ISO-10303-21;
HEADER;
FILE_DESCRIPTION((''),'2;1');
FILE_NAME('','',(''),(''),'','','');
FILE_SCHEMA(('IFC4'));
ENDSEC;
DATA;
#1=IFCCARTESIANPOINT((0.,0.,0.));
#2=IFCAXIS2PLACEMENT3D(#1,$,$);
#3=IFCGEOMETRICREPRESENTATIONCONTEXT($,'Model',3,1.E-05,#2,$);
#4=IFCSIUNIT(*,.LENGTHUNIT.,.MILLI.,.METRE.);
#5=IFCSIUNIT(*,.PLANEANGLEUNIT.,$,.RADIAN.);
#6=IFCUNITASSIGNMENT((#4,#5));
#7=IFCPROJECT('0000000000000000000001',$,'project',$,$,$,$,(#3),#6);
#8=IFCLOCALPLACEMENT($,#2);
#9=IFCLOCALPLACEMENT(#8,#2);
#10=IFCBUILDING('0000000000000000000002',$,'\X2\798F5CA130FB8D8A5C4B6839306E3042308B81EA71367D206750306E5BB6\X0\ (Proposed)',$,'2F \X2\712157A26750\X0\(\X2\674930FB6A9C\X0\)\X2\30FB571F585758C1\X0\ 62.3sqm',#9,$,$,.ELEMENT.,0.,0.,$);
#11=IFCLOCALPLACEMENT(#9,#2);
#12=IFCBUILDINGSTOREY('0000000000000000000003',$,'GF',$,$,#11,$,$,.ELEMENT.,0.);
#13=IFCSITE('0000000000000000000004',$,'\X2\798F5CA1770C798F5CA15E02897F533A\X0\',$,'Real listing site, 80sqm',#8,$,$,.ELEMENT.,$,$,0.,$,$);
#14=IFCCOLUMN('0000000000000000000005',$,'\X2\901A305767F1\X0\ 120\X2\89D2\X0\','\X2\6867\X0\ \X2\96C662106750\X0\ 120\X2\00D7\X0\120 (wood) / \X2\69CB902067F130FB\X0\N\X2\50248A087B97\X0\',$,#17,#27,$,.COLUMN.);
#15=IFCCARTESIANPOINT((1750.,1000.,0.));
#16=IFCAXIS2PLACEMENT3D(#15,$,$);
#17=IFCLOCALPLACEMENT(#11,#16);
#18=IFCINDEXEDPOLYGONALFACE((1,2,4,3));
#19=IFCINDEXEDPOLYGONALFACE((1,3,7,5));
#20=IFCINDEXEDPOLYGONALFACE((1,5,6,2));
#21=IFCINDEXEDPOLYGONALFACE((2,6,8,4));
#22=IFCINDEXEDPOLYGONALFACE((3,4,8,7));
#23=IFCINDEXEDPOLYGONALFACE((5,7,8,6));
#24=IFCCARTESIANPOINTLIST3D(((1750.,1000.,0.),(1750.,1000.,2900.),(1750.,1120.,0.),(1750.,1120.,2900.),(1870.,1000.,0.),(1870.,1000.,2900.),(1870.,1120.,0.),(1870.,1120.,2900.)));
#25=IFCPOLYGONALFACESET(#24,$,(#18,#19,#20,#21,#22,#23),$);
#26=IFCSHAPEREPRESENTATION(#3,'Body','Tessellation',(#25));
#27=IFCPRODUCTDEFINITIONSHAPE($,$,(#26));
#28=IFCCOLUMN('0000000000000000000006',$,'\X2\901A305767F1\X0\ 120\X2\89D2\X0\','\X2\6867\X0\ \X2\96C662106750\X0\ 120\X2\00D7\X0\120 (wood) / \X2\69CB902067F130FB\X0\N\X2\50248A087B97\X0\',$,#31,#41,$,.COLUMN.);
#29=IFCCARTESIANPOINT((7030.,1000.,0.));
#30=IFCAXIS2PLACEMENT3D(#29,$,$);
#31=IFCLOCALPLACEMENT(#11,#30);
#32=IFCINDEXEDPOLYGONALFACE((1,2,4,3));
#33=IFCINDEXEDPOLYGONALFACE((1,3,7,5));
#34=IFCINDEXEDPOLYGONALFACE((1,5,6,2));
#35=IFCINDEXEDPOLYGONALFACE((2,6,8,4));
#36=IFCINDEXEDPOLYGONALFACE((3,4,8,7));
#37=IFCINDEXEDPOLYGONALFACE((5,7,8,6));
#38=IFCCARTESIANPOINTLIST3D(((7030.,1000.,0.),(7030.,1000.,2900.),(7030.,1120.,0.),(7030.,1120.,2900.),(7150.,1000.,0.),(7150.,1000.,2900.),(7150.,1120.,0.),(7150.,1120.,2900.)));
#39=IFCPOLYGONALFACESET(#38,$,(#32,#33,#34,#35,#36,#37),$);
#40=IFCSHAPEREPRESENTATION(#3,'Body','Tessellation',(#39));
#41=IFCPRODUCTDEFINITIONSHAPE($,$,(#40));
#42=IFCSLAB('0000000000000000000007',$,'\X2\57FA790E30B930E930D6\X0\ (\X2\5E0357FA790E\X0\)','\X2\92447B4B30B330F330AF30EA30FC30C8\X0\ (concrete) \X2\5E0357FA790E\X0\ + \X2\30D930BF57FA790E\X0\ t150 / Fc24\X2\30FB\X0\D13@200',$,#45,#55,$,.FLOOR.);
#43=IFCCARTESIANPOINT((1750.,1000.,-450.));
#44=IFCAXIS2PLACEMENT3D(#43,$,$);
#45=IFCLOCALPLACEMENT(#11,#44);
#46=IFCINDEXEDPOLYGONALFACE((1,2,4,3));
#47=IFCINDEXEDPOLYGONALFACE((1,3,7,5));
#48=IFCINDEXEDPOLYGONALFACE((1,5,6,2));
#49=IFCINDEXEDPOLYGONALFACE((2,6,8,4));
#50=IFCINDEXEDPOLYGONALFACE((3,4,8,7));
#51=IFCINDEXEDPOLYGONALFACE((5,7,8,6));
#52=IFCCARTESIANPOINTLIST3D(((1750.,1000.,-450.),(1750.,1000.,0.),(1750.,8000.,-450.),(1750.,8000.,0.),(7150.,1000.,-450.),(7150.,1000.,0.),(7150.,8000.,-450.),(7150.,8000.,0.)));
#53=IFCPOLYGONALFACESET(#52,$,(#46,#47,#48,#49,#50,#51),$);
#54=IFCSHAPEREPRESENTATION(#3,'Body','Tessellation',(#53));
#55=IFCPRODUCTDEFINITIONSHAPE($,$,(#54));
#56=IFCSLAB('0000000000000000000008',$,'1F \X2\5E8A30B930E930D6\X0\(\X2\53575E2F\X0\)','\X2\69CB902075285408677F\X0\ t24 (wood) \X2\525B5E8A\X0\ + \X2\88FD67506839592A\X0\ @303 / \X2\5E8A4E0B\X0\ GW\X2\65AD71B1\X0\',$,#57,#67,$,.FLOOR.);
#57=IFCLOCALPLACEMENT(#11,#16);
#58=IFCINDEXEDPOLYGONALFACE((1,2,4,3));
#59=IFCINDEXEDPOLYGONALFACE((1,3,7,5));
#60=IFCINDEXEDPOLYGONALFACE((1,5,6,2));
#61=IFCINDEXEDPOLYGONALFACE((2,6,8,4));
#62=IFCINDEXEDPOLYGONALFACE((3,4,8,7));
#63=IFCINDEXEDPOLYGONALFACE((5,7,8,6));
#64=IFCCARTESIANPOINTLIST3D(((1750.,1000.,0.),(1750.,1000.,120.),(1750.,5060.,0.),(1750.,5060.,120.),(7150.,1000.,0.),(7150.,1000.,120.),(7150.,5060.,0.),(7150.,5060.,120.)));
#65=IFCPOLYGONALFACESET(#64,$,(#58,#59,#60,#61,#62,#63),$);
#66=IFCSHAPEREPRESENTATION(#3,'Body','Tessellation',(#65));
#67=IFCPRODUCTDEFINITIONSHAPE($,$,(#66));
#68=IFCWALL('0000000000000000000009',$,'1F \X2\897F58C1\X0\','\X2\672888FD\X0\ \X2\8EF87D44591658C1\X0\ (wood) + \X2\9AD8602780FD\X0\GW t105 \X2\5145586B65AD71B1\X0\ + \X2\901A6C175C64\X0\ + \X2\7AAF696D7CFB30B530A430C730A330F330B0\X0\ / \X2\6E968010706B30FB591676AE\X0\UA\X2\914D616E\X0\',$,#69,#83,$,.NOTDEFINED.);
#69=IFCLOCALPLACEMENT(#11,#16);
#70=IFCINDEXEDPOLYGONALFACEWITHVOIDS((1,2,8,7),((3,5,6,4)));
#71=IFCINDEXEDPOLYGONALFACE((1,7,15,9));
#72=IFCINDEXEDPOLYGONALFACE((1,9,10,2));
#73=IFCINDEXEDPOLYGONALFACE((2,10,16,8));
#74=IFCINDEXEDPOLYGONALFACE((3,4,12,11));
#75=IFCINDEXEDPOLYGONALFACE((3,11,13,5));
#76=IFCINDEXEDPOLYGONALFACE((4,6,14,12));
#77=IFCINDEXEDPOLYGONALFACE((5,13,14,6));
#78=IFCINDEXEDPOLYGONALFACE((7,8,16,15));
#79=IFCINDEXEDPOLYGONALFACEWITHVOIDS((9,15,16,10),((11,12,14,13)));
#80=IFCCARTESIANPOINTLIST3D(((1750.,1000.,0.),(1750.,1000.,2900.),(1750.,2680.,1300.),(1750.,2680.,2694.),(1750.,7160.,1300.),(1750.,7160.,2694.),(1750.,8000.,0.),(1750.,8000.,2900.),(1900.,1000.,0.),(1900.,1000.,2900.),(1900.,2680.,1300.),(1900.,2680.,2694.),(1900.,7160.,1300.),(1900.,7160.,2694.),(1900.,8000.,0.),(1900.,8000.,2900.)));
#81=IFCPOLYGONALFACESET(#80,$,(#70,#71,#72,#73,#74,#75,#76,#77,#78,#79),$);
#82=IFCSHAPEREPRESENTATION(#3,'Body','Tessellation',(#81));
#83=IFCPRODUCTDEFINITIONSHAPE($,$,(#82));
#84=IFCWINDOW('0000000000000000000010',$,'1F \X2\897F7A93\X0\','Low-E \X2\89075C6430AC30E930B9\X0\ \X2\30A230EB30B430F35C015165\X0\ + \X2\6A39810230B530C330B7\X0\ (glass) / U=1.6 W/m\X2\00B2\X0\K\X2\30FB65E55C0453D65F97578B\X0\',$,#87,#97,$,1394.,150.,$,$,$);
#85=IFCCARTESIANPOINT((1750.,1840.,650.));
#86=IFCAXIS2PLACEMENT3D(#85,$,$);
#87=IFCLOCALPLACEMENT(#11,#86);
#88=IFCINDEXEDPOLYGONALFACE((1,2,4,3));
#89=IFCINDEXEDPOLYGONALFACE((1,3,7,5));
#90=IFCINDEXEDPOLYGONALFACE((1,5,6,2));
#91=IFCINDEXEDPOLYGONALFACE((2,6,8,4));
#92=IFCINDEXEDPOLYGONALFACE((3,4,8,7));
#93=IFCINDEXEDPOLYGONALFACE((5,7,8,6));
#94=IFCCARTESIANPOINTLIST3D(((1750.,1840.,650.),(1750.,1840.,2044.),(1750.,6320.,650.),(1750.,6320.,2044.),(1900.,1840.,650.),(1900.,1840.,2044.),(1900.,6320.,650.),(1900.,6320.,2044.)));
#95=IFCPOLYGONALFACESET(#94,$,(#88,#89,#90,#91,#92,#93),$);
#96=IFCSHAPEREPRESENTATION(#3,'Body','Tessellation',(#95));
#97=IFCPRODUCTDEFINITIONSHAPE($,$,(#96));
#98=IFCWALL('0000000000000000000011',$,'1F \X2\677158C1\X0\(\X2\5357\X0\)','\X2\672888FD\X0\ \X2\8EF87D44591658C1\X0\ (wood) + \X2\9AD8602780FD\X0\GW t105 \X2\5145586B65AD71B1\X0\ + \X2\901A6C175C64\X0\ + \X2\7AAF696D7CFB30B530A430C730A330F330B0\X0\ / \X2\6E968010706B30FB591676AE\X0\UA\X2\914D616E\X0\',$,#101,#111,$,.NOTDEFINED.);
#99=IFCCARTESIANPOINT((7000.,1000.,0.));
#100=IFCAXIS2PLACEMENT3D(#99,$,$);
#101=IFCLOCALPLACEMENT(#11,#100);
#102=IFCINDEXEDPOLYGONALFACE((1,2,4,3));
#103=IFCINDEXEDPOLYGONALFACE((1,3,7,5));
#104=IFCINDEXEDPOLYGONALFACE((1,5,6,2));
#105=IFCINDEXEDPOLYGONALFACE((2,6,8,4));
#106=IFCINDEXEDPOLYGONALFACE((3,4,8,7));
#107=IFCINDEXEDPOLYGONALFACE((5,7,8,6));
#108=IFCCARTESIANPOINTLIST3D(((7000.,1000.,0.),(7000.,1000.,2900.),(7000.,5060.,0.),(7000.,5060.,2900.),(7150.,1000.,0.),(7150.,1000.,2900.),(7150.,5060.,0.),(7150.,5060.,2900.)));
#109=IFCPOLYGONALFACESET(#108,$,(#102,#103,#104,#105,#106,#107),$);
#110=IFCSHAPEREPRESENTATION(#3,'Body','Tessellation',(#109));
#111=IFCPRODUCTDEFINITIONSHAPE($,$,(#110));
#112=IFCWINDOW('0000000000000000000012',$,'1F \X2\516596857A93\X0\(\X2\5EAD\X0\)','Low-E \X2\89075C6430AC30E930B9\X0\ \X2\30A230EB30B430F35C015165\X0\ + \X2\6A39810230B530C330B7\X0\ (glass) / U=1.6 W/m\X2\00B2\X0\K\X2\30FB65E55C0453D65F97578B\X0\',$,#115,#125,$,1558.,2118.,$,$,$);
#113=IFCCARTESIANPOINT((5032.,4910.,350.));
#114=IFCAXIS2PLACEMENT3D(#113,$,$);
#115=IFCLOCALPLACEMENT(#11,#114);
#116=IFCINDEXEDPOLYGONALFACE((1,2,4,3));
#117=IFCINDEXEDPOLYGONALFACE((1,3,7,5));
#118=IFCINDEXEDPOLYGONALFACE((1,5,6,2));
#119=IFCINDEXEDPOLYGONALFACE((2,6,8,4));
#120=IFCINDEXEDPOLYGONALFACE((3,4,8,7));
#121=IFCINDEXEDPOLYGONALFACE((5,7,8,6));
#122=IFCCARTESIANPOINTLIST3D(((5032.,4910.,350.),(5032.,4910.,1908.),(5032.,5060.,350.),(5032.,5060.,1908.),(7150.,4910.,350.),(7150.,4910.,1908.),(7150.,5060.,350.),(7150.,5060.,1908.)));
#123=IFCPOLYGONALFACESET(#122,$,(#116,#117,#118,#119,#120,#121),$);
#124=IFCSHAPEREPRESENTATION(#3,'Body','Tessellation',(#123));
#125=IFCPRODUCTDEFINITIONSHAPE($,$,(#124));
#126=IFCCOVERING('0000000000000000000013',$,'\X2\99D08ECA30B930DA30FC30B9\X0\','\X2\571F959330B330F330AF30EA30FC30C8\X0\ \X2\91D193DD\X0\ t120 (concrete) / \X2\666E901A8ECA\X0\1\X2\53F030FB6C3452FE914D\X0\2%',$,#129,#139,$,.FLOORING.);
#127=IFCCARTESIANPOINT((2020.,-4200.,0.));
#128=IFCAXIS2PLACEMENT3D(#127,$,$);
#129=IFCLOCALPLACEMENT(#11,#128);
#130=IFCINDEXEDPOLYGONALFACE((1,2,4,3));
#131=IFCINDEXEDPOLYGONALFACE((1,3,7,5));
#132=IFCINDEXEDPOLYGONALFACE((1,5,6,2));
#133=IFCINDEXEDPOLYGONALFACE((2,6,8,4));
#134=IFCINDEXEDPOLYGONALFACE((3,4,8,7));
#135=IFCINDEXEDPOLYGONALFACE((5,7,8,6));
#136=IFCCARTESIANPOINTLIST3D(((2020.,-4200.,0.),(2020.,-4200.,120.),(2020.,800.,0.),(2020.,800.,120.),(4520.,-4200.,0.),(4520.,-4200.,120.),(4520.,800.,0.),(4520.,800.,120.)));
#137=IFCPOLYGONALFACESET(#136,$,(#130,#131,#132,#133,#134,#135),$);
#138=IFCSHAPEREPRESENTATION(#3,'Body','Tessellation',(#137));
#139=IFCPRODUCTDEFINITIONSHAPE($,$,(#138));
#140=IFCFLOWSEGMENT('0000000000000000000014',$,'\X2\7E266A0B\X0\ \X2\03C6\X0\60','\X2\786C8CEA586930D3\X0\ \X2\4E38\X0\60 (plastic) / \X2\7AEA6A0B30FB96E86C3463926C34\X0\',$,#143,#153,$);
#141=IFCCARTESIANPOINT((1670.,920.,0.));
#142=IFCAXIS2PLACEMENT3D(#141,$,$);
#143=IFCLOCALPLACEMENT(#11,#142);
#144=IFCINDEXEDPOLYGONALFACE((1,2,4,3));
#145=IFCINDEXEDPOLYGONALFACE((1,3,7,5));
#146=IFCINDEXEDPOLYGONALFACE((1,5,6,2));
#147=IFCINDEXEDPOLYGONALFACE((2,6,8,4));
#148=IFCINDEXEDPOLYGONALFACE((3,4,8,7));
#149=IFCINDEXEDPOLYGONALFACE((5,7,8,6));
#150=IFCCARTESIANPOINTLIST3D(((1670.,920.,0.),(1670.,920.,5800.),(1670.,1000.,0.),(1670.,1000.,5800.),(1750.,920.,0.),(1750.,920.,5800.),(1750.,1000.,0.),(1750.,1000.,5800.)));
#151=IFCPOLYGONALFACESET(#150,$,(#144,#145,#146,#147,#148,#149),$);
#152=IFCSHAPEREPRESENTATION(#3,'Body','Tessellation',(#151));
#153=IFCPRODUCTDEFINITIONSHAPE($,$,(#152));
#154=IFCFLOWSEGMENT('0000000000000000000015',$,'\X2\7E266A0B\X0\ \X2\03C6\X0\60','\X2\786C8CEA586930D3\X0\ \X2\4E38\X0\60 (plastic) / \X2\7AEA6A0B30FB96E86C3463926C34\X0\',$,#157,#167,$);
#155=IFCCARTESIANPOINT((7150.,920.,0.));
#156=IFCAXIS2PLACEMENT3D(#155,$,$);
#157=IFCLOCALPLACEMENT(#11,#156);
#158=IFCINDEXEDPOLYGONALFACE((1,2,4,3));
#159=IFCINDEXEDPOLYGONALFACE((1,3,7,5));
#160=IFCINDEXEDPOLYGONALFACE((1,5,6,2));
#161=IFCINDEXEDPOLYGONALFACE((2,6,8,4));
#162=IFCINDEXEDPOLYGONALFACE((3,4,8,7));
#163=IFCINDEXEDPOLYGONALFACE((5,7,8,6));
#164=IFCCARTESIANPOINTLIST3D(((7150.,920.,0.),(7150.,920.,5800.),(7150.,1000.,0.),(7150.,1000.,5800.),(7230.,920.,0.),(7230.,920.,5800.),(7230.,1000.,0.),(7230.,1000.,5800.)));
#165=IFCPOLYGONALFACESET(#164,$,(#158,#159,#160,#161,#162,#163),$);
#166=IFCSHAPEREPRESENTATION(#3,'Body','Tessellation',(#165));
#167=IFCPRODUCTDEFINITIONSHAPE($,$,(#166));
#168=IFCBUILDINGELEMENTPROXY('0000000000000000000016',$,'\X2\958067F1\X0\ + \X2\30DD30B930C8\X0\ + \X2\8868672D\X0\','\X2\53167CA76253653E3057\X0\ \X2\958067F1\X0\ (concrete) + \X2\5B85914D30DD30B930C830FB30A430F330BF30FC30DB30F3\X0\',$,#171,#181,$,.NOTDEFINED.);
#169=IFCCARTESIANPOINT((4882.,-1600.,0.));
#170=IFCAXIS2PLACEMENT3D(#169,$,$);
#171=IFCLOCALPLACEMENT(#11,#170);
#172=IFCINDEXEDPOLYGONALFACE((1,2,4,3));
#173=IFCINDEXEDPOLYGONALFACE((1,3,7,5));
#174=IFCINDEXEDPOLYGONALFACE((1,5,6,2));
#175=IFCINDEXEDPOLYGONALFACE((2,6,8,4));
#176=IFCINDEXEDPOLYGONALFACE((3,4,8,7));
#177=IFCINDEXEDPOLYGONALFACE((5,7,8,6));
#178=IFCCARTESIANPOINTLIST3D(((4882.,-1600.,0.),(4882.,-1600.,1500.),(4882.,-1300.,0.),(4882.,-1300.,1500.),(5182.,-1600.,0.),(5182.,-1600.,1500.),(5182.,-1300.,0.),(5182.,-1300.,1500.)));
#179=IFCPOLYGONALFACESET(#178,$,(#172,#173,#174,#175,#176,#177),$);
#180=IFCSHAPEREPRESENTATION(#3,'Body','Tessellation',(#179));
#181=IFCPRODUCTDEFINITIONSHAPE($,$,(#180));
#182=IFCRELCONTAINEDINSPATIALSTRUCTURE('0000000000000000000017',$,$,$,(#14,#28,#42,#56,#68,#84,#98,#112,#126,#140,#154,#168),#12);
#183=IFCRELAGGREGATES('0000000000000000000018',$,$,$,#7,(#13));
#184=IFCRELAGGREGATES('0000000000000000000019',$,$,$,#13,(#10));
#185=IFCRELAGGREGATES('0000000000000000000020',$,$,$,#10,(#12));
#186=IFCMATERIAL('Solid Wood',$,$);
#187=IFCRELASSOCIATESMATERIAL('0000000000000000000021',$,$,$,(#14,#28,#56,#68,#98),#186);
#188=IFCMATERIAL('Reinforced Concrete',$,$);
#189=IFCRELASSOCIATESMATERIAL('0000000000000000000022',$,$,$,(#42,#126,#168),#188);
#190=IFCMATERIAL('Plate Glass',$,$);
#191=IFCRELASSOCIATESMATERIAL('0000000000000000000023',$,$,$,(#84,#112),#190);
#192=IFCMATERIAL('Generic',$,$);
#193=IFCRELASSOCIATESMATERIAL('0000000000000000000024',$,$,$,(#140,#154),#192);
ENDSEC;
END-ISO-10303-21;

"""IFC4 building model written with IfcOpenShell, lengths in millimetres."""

from ifc_helpers import new_model, si_unit, frame, frame_2d, origin, place, context, project, spatial, rectangle, extrude, material, element, fill, save


model = new_model("IFC4")

# Units and contexts
model_context = context("Model", 3, precision=1e-05, world=origin())
ifc_project = project(units=[si_unit("LENGTHUNIT", "METRE", prefix="MILLI"), si_unit("PLANEANGLEUNIT", "RADIAN")], contexts=[model_context])

# Site, building, storey
site_placement = place(None, origin())
site = spatial("IfcSite", under=ifc_project, at=site_placement, Name="福岡県福岡市西区", ObjectType="Real listing site, 80sqm", CompositionType="ELEMENT", RefElevation=0.0)
building_placement = place(site_placement, origin())
building = spatial("IfcBuilding", under=site, at=building_placement, Name="福岡・越屋根のある自然素材の家 (Proposed)", ObjectType="2F 無垢材(杉・檜)・土塗壁 62.3sqm", CompositionType="ELEMENT", ElevationOfRefHeight=0.0, ElevationOfTerrain=0.0)
storey_placement = place(building_placement, origin())
storey = spatial("IfcBuildingStorey", under=building, at=storey_placement, Name="GF", CompositionType="ELEMENT", Elevation=0.0)

# Columns
ifc_material_1 = material(Name="Solid Wood")
column_1_placement = place(storey_placement, frame((1750.0, 1000.0, 0.0)))
element("IfcColumn", 1, at=column_1_placement, inside=storey, material=ifc_material_1, Name="通し柱 120角", Description="桧 集成材 120×120 (wood) / 構造柱・N値計算", PredefinedType="COLUMN", context=model_context, shape_type="SweptSolid", body=[
    extrude(rectangle(XDim=120.0, YDim=120.0, at=frame_2d((60.0, 60.0))), frame((1750.0, 1000.0, 0.0)), (0.0, 0.0, 1.0), 2900.0),
])
column_2_placement = place(storey_placement, frame((7030.0, 1000.0, 0.0)))
element("IfcColumn", 2, at=column_2_placement, inside=storey, material=ifc_material_1, Name="通し柱 120角", Description="桧 集成材 120×120 (wood) / 構造柱・N値計算", PredefinedType="COLUMN", context=model_context, shape_type="SweptSolid", body=[
    extrude(rectangle(XDim=120.0, YDim=120.0, at=frame_2d((60.0, 60.0))), frame((7030.0, 1000.0, 0.0)), (0.0, 0.0, 1.0), 2900.0),
])

# Slabs
ifc_material_2 = material(Name="Reinforced Concrete")
slab_1_placement = place(storey_placement, frame((1750.0, 1000.0, -450.0)))
element("IfcSlab", 3, at=slab_1_placement, inside=storey, material=ifc_material_2, Name="基礎スラブ (布基礎)", Description="鉄筋コンクリート (concrete) 布基礎 + ベタ基礎 t150 / Fc24・D13@200", PredefinedType="FLOOR", context=model_context, shape_type="SweptSolid", body=[
    extrude(rectangle(XDim=5400.0, YDim=7000.0, at=frame_2d((2700.0, 3500.0))), frame((1750.0, 1000.0, -450.0)), (0.0, 0.0, 1.0), 450.0),
])
slab_2_placement = place(storey_placement, frame((1750.0, 1000.0, 0.0)))
element("IfcSlab", 4, at=slab_2_placement, inside=storey, material=ifc_material_1, Name="1F 床スラブ(南帯)", Description="構造用合板 t24 (wood) 剛床 + 製材根太 @303 / 床下 GW断熱", PredefinedType="FLOOR", context=model_context, shape_type="SweptSolid", body=[
    extrude(rectangle(XDim=5400.0, YDim=4060.0, at=frame_2d((2700.0, 2030.0))), frame((1750.0, 1000.0, 0.0)), (0.0, 0.0, 1.0), 120.0),
])

# Shared definitions
ifc_material_3 = material(Name="Plate Glass")

# Walls, openings, windows
wall_1_placement = place(storey_placement, frame((1750.0, 1000.0, 0.0)))
wall_1 = element("IfcWall", 5, at=wall_1_placement, inside=storey, material=ifc_material_1, Name="1F 西壁", Description="木製 軸組外壁 (wood) + 高性能GW t105 充填断熱 + 通気層 + 窯業系サイディング / 準耐火・外皮UA配慮", PredefinedType="NOTDEFINED", context=model_context, shape_type="SweptSolid", body=[
    extrude(rectangle(XDim=150.0, YDim=7000.0, at=frame_2d((75.0, 3500.0))), frame((1750.0, 1000.0, 0.0)), (0.0, 0.0, 1.0), 2900.0),
])
opening_1_placement = place(storey_placement, frame((1750.0, 1840.0, 650.0)))
opening_1 = element("IfcOpeningElement", 6, at=opening_1_placement, cuts=wall_1, PredefinedType="NOTDEFINED", context=model_context, shape_type="SweptSolid", body=[
    extrude(rectangle(XDim=150.0, YDim=4480.0, at=frame_2d((75.0, 2240.0))), frame((1750.0, 1840.0, 650.0)), (0.0, 0.0, 1.0), 1394.0),
])
window_1_placement = place(storey_placement, frame((1750.0, 1840.0, 650.0)))
window_1 = element("IfcWindow", 7, at=window_1_placement, inside=storey, material=ifc_material_3, Name="1F 西窓", Description="Low-E 複層ガラス アルゴン封入 + 樹脂サッシ (glass) / U=1.6 W/m²K・日射取得型", OverallHeight=1394.0, OverallWidth=150.0, context=model_context, shape_type="SweptSolid", body=[
    extrude(rectangle(XDim=150.0, YDim=4480.0, at=frame_2d((75.0, 2240.0))), frame((1750.0, 1840.0, 650.0)), (0.0, 0.0, 1.0), 1394.0),
])
fill(opening_1, window_1)
wall_2_placement = place(storey_placement, frame((7000.0, 1000.0, 0.0)))
wall_2 = element("IfcWall", 8, at=wall_2_placement, inside=storey, material=ifc_material_1, Name="1F 東壁(南)", Description="木製 軸組外壁 (wood) + 高性能GW t105 充填断熱 + 通気層 + 窯業系サイディング / 準耐火・外皮UA配慮", PredefinedType="NOTDEFINED", context=model_context, shape_type="SweptSolid", body=[
    extrude(rectangle(XDim=150.0, YDim=4060.0, at=frame_2d((75.0, 2030.0))), frame((7000.0, 1000.0, 0.0)), (0.0, 0.0, 1.0), 2900.0),
])
opening_2_placement = place(storey_placement, frame((5032.0, 4910.0, 350.0)))
opening_2 = element("IfcOpeningElement", 9, at=opening_2_placement, cuts=wall_2, PredefinedType="NOTDEFINED", context=model_context, shape_type="SweptSolid", body=[
    extrude(rectangle(XDim=2118.0, YDim=150.0, at=frame_2d((1059.0, 75.0))), frame((5032.0, 4910.0, 350.0)), (0.0, 0.0, 1.0), 1558.0),
])
window_2_placement = place(storey_placement, frame((5032.0, 4910.0, 350.0)))
window_2 = element("IfcWindow", 10, at=window_2_placement, inside=storey, material=ifc_material_3, Name="1F 入隅窓(庭)", Description="Low-E 複層ガラス アルゴン封入 + 樹脂サッシ (glass) / U=1.6 W/m²K・日射取得型", OverallHeight=1558.0, OverallWidth=2118.0, context=model_context, shape_type="SweptSolid", body=[
    extrude(rectangle(XDim=2118.0, YDim=150.0, at=frame_2d((1059.0, 75.0))), frame((5032.0, 4910.0, 350.0)), (0.0, 0.0, 1.0), 1558.0),
])
fill(opening_2, window_2)

# Covering
covering_1_placement = place(storey_placement, frame((2020.0, -4200.0, 0.0)))
element("IfcCovering", 11, at=covering_1_placement, inside=storey, material=ifc_material_2, Name="駐車スペース", Description="土間コンクリート 金鏝 t120 (concrete) / 普通車1台・水勾配2%", PredefinedType="FLOORING", context=model_context, shape_type="SweptSolid", body=[
    extrude(rectangle(XDim=2500.0, YDim=5000.0, at=frame_2d((1250.0, 2500.0))), frame((2020.0, -4200.0, 0.0)), (0.0, 0.0, 1.0), 120.0),
])

# Flow segments
ifc_material_4 = material(Name="Generic")
flow_segment_1_placement = place(storey_placement, frame((1670.0, 920.0, 0.0)))
element("IfcFlowSegment", 12, at=flow_segment_1_placement, inside=storey, material=ifc_material_4, Name="縦樋 φ60", Description="硬質塩ビ 丸60 (plastic) / 竪樋・雨水排水", context=model_context, shape_type="SweptSolid", body=[
    extrude(rectangle(XDim=80.0, YDim=80.0, at=frame_2d((40.0, 40.0))), frame((1670.0, 920.0, 0.0)), (0.0, 0.0, 1.0), 5800.0),
])
flow_segment_2_placement = place(storey_placement, frame((7150.0, 920.0, 0.0)))
element("IfcFlowSegment", 13, at=flow_segment_2_placement, inside=storey, material=ifc_material_4, Name="縦樋 φ60", Description="硬質塩ビ 丸60 (plastic) / 竪樋・雨水排水", context=model_context, shape_type="SweptSolid", body=[
    extrude(rectangle(XDim=80.0, YDim=80.0, at=frame_2d((40.0, 40.0))), frame((7150.0, 920.0, 0.0)), (0.0, 0.0, 1.0), 5800.0),
])

# Building element proxy
proxy_placement = place(storey_placement, frame((4882.0, -1600.0, 0.0)))
element("IfcBuildingElementProxy", 14, at=proxy_placement, inside=storey, material=ifc_material_2, Name="門柱 + ポスト + 表札", Description="化粧打放し 門柱 (concrete) + 宅配ポスト・インターホン", PredefinedType="NOTDEFINED", context=model_context, shape_type="SweptSolid", body=[
    extrude(rectangle(XDim=300.0, YDim=300.0, at=frame_2d((150.0, 150.0))), frame((4882.0, -1600.0, 0.0)), (0.0, 0.0, 1.0), 1500.0),
])

save(model, "model.ifc")
